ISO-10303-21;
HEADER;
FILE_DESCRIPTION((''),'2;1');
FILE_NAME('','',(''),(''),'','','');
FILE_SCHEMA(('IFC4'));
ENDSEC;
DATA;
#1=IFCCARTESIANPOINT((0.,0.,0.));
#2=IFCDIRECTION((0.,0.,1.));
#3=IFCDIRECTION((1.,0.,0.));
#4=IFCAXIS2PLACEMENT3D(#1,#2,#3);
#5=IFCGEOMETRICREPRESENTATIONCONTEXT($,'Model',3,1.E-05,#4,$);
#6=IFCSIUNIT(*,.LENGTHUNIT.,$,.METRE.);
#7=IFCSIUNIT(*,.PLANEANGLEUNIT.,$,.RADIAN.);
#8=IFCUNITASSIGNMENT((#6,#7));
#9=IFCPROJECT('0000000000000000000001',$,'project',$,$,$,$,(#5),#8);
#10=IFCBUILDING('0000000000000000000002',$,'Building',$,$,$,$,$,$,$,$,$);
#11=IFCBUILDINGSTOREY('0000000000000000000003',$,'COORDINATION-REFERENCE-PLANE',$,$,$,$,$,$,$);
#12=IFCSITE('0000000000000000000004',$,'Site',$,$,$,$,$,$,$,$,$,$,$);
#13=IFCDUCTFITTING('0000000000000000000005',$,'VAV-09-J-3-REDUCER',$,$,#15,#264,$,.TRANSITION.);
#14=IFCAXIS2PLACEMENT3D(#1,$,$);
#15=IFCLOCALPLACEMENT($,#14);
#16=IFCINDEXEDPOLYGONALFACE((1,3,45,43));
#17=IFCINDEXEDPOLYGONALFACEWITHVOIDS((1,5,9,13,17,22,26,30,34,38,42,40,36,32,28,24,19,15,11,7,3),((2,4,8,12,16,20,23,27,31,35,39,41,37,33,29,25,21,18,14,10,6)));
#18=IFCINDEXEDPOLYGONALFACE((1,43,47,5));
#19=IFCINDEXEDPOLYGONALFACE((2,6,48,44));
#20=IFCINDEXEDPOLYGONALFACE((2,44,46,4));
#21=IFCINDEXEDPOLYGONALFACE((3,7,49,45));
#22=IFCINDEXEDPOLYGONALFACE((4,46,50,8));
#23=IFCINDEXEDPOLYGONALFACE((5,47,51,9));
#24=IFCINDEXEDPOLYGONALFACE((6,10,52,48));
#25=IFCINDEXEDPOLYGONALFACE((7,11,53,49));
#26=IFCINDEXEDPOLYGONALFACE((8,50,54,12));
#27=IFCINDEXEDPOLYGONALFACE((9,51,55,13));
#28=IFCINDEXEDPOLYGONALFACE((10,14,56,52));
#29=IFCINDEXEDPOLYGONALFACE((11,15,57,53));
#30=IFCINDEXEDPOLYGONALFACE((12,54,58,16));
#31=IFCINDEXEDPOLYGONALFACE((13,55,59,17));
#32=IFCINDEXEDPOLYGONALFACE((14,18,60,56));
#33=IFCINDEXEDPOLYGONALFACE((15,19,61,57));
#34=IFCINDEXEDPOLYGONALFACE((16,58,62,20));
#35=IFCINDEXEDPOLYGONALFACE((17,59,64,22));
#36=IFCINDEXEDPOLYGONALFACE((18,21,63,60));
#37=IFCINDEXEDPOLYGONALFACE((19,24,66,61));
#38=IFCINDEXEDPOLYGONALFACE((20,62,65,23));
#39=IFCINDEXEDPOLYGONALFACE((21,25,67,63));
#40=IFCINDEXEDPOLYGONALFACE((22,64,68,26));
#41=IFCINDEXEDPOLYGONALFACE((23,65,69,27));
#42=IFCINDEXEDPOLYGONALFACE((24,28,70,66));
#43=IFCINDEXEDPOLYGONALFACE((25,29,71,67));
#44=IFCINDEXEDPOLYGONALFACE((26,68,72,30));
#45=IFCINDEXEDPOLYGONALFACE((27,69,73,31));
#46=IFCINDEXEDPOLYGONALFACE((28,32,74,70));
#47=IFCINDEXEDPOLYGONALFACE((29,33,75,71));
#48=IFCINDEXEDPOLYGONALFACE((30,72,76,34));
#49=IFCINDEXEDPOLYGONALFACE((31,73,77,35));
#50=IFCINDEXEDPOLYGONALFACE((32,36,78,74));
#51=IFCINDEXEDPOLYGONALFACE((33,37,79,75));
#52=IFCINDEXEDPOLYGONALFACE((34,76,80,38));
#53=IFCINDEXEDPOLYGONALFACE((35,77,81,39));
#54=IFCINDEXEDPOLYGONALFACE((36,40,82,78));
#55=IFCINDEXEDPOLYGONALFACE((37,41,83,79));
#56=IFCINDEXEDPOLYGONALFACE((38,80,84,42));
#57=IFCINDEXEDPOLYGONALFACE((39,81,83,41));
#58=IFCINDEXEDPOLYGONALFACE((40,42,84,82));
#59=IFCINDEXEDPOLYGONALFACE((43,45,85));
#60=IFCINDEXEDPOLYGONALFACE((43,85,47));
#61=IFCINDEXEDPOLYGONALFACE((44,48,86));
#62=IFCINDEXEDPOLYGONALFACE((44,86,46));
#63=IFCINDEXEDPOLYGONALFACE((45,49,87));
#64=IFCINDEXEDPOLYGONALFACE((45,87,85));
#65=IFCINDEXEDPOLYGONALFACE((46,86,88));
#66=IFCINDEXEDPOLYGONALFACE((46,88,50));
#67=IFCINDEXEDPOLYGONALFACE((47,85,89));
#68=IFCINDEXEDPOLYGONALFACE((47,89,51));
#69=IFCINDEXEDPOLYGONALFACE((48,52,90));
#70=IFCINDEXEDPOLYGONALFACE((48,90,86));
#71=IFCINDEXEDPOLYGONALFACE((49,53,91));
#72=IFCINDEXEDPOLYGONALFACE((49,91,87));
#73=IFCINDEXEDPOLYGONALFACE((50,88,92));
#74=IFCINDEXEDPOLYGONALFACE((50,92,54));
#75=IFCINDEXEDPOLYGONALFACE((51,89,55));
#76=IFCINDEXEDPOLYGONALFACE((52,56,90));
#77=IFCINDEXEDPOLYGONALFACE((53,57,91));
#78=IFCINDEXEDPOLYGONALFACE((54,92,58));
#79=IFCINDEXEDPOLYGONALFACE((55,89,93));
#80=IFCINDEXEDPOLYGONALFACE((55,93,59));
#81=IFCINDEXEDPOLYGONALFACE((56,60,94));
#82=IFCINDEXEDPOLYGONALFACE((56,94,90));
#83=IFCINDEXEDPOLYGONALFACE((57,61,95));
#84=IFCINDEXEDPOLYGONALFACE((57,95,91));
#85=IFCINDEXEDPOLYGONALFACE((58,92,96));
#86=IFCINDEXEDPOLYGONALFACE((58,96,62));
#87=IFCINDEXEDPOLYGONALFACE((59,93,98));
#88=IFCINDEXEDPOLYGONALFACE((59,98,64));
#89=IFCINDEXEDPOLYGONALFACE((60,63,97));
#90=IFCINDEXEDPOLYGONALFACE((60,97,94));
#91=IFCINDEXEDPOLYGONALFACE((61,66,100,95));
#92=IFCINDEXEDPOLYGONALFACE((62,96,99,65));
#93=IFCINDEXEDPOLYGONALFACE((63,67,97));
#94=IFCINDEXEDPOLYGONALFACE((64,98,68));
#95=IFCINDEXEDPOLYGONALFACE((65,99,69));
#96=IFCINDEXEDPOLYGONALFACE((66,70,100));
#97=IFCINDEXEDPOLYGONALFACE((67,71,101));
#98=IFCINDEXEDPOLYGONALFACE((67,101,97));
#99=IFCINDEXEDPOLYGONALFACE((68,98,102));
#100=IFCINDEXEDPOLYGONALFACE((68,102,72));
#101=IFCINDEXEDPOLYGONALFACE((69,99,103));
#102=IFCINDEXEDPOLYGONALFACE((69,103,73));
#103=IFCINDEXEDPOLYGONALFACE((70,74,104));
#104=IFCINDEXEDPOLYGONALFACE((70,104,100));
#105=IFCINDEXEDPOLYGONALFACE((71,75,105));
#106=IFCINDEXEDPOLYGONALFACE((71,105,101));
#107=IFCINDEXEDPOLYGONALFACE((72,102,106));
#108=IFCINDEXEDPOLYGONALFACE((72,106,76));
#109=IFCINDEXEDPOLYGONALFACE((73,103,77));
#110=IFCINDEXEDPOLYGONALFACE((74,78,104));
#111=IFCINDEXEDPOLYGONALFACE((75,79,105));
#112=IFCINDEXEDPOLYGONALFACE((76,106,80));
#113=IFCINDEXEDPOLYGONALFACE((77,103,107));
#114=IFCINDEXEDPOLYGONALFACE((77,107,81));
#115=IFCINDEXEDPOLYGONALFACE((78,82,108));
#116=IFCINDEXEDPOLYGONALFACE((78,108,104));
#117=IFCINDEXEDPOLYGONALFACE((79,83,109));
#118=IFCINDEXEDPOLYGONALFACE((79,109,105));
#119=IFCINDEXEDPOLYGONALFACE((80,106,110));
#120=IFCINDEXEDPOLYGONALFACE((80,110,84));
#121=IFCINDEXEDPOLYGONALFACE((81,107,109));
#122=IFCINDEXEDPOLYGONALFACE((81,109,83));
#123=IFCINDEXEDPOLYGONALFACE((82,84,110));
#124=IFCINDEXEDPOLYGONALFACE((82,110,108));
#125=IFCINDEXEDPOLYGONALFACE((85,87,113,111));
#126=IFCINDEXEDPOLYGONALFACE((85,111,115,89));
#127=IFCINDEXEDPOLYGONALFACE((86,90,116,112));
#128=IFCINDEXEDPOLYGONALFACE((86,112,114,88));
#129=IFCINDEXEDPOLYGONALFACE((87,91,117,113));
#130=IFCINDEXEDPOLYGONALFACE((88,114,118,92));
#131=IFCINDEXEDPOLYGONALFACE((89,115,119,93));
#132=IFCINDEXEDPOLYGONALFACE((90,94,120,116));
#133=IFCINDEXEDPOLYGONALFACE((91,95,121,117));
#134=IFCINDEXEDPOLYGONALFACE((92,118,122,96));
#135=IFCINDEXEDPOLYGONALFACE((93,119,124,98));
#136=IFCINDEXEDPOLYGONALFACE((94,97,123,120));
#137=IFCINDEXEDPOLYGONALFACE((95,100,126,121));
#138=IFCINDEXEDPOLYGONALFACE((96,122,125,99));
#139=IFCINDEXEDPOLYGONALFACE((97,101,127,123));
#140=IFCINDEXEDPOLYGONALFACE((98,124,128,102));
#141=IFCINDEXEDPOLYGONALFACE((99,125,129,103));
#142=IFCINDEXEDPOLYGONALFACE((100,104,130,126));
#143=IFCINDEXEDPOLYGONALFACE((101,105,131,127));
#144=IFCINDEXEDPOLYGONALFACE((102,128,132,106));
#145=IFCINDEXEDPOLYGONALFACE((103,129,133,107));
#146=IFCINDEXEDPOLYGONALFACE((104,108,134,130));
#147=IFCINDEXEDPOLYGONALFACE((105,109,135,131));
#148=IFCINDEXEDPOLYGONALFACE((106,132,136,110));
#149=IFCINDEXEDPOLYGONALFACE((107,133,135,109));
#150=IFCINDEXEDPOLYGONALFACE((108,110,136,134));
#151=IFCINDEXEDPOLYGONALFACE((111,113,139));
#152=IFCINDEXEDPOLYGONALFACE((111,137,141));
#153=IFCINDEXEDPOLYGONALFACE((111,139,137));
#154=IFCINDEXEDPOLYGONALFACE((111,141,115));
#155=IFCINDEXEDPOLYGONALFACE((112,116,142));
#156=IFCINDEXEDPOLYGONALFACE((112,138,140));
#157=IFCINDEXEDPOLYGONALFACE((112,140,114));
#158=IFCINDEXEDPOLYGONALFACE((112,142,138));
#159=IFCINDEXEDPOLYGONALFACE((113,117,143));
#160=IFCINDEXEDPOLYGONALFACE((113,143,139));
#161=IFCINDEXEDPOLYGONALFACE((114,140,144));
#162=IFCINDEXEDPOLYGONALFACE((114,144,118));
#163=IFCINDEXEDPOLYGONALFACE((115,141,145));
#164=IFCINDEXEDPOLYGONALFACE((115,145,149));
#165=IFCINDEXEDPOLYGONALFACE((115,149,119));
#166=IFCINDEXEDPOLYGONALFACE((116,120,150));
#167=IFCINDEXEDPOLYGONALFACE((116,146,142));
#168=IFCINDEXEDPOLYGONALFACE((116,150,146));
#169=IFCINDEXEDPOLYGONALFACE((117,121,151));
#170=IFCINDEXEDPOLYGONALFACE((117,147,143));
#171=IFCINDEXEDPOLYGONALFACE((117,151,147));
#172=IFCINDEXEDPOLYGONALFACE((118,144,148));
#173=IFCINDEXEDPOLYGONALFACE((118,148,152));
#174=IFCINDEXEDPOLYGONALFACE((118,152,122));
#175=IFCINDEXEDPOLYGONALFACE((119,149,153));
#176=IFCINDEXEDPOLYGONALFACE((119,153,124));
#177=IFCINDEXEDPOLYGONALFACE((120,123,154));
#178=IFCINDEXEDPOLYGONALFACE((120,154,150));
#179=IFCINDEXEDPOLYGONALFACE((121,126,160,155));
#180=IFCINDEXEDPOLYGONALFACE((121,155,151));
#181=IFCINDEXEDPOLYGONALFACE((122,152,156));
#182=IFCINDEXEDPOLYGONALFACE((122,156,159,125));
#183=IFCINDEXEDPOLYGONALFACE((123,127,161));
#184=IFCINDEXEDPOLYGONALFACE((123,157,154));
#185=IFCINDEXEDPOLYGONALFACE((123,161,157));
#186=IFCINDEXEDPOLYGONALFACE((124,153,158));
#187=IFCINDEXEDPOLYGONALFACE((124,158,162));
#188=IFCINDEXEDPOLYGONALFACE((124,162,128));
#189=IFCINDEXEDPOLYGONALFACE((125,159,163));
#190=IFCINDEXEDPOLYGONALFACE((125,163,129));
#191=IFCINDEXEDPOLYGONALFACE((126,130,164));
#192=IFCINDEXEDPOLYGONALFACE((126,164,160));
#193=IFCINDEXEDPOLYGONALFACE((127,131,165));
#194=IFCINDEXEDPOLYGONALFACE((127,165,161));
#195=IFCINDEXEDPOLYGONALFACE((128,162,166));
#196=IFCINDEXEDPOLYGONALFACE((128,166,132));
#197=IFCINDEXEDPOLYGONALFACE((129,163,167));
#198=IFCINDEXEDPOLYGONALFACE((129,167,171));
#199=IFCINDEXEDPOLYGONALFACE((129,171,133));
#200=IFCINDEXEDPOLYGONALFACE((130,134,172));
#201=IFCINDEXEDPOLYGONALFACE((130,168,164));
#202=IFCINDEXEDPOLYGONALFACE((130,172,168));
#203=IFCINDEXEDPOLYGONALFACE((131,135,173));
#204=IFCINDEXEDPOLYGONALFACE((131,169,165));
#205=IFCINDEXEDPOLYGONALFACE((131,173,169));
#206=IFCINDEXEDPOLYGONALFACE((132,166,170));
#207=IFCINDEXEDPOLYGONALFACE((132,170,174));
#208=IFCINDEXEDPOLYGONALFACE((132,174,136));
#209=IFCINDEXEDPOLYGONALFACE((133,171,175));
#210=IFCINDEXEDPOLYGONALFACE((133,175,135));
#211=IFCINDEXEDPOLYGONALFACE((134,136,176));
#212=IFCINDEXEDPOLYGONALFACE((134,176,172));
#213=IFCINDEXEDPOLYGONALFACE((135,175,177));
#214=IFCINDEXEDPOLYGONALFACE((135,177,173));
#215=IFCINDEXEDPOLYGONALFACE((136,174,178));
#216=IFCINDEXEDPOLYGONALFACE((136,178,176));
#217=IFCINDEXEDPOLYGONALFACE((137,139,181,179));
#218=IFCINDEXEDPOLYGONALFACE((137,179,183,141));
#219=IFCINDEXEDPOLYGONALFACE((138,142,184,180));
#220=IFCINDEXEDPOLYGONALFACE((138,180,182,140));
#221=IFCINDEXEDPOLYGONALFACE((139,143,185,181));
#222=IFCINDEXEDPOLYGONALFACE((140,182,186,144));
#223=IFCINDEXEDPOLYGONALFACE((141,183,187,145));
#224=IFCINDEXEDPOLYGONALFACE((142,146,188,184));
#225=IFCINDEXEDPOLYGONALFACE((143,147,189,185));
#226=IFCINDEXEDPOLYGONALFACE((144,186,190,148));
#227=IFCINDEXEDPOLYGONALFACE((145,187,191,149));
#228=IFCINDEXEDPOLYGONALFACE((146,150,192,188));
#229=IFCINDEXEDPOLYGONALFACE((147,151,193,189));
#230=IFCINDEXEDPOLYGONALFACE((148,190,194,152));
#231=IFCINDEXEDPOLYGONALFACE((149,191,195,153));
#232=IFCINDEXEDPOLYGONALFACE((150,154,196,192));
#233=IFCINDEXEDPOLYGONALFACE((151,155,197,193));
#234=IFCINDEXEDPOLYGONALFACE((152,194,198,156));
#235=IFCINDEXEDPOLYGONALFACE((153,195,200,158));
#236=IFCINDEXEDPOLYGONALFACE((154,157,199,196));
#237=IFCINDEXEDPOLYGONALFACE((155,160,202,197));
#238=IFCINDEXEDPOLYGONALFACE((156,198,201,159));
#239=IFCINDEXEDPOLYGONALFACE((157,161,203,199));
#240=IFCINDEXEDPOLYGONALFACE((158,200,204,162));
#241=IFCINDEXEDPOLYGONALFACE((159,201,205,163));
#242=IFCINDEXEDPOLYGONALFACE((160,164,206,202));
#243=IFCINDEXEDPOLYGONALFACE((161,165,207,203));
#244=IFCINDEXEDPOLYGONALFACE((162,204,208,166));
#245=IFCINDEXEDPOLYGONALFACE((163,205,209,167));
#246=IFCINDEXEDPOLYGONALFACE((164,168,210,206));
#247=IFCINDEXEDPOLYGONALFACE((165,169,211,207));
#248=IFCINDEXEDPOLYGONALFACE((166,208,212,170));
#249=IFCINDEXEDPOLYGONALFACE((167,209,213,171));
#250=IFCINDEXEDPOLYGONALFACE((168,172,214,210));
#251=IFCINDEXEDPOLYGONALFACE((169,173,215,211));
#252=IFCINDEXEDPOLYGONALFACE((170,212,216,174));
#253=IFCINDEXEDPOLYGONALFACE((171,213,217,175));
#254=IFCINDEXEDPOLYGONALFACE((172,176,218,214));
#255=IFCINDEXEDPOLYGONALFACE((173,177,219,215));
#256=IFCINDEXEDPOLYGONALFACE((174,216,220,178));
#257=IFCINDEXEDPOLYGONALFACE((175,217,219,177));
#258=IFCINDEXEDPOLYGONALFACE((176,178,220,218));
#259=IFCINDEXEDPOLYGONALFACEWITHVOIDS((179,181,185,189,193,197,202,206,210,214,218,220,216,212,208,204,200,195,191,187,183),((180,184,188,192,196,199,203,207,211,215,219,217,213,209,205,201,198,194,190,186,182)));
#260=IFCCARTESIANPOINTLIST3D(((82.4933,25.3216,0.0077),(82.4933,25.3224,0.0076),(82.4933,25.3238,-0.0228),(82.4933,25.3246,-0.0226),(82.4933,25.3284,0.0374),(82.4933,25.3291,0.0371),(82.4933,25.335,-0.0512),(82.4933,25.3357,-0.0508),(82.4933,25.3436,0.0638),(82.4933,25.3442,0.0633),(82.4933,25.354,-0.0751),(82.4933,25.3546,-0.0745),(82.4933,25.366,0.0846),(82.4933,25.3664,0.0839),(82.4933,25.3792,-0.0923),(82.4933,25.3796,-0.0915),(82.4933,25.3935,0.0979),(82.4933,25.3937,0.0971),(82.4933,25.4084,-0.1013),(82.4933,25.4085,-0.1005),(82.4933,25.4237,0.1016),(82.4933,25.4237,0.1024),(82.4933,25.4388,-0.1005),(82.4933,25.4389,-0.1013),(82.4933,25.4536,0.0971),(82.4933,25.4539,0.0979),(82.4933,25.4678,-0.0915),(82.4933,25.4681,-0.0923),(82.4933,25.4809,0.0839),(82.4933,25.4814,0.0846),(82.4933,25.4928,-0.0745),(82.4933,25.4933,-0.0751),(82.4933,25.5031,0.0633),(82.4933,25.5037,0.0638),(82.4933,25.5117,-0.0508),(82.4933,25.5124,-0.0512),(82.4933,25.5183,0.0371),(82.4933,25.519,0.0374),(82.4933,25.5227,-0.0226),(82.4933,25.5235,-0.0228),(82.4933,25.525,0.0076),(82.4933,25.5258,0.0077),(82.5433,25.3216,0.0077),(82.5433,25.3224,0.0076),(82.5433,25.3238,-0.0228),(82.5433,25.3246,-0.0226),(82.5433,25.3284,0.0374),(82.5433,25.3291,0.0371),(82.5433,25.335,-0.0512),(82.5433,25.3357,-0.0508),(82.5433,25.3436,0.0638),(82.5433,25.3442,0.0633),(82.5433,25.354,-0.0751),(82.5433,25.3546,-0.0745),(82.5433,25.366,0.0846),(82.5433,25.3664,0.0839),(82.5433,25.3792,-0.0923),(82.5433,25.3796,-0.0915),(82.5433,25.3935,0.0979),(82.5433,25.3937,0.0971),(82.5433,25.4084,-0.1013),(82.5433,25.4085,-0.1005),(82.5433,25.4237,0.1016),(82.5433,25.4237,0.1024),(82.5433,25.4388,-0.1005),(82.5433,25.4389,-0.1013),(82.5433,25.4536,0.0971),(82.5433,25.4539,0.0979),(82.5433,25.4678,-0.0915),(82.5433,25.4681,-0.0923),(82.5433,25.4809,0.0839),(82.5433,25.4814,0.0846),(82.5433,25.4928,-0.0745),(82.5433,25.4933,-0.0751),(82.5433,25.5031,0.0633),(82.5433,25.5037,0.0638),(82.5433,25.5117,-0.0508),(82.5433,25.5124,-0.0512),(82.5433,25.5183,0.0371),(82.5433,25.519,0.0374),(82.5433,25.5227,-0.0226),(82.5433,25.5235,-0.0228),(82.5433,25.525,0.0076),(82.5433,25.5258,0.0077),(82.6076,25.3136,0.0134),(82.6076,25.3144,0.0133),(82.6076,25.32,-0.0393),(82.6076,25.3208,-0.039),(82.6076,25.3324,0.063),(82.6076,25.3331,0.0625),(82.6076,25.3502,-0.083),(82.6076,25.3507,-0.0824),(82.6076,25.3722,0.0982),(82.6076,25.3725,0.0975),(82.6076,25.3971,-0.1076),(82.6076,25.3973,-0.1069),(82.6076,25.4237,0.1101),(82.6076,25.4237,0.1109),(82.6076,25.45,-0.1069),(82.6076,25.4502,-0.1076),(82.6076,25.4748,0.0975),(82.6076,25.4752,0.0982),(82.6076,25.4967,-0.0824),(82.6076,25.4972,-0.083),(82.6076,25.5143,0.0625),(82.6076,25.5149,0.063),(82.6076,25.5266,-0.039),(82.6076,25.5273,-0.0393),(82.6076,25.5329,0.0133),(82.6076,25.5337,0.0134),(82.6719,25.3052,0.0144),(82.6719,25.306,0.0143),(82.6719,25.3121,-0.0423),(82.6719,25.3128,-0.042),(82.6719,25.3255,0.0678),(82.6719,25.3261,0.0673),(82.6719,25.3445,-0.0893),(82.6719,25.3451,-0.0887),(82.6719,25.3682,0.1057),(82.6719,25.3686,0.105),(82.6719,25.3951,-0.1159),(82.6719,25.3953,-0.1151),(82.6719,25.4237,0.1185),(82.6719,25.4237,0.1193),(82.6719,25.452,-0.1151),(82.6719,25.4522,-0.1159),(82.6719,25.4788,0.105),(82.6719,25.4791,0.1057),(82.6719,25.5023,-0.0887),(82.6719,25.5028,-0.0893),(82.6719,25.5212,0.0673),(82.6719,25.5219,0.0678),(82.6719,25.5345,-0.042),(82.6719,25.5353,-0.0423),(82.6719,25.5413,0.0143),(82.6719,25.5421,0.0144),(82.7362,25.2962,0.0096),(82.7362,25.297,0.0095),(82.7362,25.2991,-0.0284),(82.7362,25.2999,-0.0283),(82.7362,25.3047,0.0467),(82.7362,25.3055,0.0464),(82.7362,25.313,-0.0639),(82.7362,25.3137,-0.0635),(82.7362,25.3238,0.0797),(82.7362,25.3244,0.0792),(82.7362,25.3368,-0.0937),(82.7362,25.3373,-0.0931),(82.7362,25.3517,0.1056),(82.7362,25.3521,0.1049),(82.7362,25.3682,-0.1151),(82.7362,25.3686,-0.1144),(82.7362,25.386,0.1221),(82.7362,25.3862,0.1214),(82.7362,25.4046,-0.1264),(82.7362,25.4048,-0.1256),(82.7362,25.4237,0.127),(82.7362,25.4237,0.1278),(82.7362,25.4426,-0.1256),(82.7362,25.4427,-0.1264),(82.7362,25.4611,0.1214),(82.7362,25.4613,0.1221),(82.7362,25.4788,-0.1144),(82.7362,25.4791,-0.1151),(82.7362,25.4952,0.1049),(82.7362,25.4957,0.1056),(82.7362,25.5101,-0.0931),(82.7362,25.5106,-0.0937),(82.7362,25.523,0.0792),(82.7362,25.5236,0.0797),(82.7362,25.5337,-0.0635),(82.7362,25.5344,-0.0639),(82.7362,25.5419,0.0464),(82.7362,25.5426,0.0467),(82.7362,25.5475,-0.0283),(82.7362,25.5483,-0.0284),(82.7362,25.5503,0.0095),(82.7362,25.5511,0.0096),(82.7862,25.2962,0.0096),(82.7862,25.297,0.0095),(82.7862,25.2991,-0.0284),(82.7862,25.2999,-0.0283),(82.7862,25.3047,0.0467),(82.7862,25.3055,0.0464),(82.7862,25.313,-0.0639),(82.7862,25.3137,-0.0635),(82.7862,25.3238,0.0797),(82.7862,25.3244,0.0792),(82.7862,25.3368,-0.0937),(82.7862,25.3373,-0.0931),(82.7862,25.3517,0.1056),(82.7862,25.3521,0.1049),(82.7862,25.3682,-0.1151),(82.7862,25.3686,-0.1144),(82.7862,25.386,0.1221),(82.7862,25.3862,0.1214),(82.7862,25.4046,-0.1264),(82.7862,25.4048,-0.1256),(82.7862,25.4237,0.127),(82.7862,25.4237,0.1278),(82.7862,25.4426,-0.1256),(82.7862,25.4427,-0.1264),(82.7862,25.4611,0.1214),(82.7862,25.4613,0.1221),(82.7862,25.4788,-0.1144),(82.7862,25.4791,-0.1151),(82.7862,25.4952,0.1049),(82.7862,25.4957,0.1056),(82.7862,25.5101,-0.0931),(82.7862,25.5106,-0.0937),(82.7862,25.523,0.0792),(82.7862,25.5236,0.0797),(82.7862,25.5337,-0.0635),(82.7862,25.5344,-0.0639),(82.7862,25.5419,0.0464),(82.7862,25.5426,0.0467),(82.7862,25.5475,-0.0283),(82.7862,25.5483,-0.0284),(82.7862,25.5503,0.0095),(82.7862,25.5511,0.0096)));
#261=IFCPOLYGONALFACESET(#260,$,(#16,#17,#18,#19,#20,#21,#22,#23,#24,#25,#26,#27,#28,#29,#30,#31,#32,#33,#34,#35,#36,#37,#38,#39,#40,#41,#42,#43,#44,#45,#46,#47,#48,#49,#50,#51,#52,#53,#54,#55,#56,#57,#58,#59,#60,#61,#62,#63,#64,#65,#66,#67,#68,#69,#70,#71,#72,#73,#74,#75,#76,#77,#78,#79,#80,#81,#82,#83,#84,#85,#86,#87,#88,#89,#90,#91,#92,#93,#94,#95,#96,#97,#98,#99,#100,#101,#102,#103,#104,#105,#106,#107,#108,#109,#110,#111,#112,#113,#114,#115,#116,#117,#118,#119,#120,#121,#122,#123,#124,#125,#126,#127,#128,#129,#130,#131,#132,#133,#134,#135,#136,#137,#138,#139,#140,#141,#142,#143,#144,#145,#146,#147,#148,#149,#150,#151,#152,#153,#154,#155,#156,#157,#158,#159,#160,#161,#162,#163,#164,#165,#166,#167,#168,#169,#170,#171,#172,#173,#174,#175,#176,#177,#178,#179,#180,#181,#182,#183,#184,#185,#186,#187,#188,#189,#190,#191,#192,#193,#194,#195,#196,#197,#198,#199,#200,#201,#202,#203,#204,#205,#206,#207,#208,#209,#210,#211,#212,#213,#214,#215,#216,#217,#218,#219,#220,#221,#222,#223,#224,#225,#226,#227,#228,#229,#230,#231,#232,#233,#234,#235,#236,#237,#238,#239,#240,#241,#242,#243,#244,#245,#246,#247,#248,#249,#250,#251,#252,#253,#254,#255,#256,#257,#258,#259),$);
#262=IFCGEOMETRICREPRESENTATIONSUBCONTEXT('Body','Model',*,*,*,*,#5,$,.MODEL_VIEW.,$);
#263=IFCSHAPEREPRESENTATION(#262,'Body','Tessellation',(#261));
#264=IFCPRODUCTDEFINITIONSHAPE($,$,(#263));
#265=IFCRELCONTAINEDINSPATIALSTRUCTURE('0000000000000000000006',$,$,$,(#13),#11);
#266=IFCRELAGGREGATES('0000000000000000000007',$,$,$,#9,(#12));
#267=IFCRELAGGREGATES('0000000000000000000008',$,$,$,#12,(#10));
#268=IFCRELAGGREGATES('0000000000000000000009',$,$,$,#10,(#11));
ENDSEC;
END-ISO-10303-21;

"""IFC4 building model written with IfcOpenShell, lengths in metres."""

from ifc_helpers import new_model, entity, si_unit, frame, origin_with_axes, place, context, subcontext, project, spatial, element, save


model = new_model("IFC4")

# Units and contexts
model_context_1 = context("Model", 3, precision=1e-05, world=origin_with_axes())
body_context_1 = subcontext(model_context_1, "Body", "Model", "MODEL_VIEW")
ifc_project = project(units=[si_unit("LENGTHUNIT", "METRE"), si_unit("PLANEANGLEUNIT", "RADIAN")], contexts=[model_context_1])

# Site, building, storey
site = spatial("IfcSite", under=ifc_project, Name="Site")
building = spatial("IfcBuilding", under=site, Name="Building")
storey = spatial("IfcBuildingStorey", under=building, Name="COORDINATION-REFERENCE-PLANE")

# Duct fitting
for number, where, z_axis, x_axis, name in (
    (1, (82.7862, 25.4237, 0.0), (0.0, -1.0, 0.0), (0.0, 0.0, 1.0), "VAV-09-J-3-REDUCER"),
):
    element("IfcDuctFitting", number, at=place(None, frame(where, z_axis=z_axis, x_axis=x_axis)), inside=storey, Name=name, PredefinedType="TRANSITION", context=body_context_1, shape_type="SweptSolid", body=[
        entity("IfcRevolvedAreaSolid", entity("IfcArbitraryClosedProfileDef", "AREA", None, entity("IfcPolyline", [entity("IfcCartesianPoint", [0.1278, 0.0]), entity("IfcCartesianPoint", [0.1278, 0.05]), entity("IfcCartesianPoint", [0.1024, 0.2429]), entity("IfcCartesianPoint", [0.1024, 0.2929]), entity("IfcCartesianPoint", [0.1016, 0.2929]), entity("IfcCartesianPoint", [0.1016, 0.2429]), entity("IfcCartesianPoint", [0.127, 0.05]), entity("IfcCartesianPoint", [0.127, 0.0]), entity("IfcCartesianPoint", [0.1278, 0.0])])), entity("IfcAxis2Placement3D", entity("IfcCartesianPoint", [0.0, 0.0, 0.0])), entity("IfcAxis1Placement", entity("IfcCartesianPoint", [0.0, 0.0, 0.0]), entity("IfcDirection", [0.0, 1.0, 0.0])), 6.283185),
    ])

save(model, "model.ifc")
